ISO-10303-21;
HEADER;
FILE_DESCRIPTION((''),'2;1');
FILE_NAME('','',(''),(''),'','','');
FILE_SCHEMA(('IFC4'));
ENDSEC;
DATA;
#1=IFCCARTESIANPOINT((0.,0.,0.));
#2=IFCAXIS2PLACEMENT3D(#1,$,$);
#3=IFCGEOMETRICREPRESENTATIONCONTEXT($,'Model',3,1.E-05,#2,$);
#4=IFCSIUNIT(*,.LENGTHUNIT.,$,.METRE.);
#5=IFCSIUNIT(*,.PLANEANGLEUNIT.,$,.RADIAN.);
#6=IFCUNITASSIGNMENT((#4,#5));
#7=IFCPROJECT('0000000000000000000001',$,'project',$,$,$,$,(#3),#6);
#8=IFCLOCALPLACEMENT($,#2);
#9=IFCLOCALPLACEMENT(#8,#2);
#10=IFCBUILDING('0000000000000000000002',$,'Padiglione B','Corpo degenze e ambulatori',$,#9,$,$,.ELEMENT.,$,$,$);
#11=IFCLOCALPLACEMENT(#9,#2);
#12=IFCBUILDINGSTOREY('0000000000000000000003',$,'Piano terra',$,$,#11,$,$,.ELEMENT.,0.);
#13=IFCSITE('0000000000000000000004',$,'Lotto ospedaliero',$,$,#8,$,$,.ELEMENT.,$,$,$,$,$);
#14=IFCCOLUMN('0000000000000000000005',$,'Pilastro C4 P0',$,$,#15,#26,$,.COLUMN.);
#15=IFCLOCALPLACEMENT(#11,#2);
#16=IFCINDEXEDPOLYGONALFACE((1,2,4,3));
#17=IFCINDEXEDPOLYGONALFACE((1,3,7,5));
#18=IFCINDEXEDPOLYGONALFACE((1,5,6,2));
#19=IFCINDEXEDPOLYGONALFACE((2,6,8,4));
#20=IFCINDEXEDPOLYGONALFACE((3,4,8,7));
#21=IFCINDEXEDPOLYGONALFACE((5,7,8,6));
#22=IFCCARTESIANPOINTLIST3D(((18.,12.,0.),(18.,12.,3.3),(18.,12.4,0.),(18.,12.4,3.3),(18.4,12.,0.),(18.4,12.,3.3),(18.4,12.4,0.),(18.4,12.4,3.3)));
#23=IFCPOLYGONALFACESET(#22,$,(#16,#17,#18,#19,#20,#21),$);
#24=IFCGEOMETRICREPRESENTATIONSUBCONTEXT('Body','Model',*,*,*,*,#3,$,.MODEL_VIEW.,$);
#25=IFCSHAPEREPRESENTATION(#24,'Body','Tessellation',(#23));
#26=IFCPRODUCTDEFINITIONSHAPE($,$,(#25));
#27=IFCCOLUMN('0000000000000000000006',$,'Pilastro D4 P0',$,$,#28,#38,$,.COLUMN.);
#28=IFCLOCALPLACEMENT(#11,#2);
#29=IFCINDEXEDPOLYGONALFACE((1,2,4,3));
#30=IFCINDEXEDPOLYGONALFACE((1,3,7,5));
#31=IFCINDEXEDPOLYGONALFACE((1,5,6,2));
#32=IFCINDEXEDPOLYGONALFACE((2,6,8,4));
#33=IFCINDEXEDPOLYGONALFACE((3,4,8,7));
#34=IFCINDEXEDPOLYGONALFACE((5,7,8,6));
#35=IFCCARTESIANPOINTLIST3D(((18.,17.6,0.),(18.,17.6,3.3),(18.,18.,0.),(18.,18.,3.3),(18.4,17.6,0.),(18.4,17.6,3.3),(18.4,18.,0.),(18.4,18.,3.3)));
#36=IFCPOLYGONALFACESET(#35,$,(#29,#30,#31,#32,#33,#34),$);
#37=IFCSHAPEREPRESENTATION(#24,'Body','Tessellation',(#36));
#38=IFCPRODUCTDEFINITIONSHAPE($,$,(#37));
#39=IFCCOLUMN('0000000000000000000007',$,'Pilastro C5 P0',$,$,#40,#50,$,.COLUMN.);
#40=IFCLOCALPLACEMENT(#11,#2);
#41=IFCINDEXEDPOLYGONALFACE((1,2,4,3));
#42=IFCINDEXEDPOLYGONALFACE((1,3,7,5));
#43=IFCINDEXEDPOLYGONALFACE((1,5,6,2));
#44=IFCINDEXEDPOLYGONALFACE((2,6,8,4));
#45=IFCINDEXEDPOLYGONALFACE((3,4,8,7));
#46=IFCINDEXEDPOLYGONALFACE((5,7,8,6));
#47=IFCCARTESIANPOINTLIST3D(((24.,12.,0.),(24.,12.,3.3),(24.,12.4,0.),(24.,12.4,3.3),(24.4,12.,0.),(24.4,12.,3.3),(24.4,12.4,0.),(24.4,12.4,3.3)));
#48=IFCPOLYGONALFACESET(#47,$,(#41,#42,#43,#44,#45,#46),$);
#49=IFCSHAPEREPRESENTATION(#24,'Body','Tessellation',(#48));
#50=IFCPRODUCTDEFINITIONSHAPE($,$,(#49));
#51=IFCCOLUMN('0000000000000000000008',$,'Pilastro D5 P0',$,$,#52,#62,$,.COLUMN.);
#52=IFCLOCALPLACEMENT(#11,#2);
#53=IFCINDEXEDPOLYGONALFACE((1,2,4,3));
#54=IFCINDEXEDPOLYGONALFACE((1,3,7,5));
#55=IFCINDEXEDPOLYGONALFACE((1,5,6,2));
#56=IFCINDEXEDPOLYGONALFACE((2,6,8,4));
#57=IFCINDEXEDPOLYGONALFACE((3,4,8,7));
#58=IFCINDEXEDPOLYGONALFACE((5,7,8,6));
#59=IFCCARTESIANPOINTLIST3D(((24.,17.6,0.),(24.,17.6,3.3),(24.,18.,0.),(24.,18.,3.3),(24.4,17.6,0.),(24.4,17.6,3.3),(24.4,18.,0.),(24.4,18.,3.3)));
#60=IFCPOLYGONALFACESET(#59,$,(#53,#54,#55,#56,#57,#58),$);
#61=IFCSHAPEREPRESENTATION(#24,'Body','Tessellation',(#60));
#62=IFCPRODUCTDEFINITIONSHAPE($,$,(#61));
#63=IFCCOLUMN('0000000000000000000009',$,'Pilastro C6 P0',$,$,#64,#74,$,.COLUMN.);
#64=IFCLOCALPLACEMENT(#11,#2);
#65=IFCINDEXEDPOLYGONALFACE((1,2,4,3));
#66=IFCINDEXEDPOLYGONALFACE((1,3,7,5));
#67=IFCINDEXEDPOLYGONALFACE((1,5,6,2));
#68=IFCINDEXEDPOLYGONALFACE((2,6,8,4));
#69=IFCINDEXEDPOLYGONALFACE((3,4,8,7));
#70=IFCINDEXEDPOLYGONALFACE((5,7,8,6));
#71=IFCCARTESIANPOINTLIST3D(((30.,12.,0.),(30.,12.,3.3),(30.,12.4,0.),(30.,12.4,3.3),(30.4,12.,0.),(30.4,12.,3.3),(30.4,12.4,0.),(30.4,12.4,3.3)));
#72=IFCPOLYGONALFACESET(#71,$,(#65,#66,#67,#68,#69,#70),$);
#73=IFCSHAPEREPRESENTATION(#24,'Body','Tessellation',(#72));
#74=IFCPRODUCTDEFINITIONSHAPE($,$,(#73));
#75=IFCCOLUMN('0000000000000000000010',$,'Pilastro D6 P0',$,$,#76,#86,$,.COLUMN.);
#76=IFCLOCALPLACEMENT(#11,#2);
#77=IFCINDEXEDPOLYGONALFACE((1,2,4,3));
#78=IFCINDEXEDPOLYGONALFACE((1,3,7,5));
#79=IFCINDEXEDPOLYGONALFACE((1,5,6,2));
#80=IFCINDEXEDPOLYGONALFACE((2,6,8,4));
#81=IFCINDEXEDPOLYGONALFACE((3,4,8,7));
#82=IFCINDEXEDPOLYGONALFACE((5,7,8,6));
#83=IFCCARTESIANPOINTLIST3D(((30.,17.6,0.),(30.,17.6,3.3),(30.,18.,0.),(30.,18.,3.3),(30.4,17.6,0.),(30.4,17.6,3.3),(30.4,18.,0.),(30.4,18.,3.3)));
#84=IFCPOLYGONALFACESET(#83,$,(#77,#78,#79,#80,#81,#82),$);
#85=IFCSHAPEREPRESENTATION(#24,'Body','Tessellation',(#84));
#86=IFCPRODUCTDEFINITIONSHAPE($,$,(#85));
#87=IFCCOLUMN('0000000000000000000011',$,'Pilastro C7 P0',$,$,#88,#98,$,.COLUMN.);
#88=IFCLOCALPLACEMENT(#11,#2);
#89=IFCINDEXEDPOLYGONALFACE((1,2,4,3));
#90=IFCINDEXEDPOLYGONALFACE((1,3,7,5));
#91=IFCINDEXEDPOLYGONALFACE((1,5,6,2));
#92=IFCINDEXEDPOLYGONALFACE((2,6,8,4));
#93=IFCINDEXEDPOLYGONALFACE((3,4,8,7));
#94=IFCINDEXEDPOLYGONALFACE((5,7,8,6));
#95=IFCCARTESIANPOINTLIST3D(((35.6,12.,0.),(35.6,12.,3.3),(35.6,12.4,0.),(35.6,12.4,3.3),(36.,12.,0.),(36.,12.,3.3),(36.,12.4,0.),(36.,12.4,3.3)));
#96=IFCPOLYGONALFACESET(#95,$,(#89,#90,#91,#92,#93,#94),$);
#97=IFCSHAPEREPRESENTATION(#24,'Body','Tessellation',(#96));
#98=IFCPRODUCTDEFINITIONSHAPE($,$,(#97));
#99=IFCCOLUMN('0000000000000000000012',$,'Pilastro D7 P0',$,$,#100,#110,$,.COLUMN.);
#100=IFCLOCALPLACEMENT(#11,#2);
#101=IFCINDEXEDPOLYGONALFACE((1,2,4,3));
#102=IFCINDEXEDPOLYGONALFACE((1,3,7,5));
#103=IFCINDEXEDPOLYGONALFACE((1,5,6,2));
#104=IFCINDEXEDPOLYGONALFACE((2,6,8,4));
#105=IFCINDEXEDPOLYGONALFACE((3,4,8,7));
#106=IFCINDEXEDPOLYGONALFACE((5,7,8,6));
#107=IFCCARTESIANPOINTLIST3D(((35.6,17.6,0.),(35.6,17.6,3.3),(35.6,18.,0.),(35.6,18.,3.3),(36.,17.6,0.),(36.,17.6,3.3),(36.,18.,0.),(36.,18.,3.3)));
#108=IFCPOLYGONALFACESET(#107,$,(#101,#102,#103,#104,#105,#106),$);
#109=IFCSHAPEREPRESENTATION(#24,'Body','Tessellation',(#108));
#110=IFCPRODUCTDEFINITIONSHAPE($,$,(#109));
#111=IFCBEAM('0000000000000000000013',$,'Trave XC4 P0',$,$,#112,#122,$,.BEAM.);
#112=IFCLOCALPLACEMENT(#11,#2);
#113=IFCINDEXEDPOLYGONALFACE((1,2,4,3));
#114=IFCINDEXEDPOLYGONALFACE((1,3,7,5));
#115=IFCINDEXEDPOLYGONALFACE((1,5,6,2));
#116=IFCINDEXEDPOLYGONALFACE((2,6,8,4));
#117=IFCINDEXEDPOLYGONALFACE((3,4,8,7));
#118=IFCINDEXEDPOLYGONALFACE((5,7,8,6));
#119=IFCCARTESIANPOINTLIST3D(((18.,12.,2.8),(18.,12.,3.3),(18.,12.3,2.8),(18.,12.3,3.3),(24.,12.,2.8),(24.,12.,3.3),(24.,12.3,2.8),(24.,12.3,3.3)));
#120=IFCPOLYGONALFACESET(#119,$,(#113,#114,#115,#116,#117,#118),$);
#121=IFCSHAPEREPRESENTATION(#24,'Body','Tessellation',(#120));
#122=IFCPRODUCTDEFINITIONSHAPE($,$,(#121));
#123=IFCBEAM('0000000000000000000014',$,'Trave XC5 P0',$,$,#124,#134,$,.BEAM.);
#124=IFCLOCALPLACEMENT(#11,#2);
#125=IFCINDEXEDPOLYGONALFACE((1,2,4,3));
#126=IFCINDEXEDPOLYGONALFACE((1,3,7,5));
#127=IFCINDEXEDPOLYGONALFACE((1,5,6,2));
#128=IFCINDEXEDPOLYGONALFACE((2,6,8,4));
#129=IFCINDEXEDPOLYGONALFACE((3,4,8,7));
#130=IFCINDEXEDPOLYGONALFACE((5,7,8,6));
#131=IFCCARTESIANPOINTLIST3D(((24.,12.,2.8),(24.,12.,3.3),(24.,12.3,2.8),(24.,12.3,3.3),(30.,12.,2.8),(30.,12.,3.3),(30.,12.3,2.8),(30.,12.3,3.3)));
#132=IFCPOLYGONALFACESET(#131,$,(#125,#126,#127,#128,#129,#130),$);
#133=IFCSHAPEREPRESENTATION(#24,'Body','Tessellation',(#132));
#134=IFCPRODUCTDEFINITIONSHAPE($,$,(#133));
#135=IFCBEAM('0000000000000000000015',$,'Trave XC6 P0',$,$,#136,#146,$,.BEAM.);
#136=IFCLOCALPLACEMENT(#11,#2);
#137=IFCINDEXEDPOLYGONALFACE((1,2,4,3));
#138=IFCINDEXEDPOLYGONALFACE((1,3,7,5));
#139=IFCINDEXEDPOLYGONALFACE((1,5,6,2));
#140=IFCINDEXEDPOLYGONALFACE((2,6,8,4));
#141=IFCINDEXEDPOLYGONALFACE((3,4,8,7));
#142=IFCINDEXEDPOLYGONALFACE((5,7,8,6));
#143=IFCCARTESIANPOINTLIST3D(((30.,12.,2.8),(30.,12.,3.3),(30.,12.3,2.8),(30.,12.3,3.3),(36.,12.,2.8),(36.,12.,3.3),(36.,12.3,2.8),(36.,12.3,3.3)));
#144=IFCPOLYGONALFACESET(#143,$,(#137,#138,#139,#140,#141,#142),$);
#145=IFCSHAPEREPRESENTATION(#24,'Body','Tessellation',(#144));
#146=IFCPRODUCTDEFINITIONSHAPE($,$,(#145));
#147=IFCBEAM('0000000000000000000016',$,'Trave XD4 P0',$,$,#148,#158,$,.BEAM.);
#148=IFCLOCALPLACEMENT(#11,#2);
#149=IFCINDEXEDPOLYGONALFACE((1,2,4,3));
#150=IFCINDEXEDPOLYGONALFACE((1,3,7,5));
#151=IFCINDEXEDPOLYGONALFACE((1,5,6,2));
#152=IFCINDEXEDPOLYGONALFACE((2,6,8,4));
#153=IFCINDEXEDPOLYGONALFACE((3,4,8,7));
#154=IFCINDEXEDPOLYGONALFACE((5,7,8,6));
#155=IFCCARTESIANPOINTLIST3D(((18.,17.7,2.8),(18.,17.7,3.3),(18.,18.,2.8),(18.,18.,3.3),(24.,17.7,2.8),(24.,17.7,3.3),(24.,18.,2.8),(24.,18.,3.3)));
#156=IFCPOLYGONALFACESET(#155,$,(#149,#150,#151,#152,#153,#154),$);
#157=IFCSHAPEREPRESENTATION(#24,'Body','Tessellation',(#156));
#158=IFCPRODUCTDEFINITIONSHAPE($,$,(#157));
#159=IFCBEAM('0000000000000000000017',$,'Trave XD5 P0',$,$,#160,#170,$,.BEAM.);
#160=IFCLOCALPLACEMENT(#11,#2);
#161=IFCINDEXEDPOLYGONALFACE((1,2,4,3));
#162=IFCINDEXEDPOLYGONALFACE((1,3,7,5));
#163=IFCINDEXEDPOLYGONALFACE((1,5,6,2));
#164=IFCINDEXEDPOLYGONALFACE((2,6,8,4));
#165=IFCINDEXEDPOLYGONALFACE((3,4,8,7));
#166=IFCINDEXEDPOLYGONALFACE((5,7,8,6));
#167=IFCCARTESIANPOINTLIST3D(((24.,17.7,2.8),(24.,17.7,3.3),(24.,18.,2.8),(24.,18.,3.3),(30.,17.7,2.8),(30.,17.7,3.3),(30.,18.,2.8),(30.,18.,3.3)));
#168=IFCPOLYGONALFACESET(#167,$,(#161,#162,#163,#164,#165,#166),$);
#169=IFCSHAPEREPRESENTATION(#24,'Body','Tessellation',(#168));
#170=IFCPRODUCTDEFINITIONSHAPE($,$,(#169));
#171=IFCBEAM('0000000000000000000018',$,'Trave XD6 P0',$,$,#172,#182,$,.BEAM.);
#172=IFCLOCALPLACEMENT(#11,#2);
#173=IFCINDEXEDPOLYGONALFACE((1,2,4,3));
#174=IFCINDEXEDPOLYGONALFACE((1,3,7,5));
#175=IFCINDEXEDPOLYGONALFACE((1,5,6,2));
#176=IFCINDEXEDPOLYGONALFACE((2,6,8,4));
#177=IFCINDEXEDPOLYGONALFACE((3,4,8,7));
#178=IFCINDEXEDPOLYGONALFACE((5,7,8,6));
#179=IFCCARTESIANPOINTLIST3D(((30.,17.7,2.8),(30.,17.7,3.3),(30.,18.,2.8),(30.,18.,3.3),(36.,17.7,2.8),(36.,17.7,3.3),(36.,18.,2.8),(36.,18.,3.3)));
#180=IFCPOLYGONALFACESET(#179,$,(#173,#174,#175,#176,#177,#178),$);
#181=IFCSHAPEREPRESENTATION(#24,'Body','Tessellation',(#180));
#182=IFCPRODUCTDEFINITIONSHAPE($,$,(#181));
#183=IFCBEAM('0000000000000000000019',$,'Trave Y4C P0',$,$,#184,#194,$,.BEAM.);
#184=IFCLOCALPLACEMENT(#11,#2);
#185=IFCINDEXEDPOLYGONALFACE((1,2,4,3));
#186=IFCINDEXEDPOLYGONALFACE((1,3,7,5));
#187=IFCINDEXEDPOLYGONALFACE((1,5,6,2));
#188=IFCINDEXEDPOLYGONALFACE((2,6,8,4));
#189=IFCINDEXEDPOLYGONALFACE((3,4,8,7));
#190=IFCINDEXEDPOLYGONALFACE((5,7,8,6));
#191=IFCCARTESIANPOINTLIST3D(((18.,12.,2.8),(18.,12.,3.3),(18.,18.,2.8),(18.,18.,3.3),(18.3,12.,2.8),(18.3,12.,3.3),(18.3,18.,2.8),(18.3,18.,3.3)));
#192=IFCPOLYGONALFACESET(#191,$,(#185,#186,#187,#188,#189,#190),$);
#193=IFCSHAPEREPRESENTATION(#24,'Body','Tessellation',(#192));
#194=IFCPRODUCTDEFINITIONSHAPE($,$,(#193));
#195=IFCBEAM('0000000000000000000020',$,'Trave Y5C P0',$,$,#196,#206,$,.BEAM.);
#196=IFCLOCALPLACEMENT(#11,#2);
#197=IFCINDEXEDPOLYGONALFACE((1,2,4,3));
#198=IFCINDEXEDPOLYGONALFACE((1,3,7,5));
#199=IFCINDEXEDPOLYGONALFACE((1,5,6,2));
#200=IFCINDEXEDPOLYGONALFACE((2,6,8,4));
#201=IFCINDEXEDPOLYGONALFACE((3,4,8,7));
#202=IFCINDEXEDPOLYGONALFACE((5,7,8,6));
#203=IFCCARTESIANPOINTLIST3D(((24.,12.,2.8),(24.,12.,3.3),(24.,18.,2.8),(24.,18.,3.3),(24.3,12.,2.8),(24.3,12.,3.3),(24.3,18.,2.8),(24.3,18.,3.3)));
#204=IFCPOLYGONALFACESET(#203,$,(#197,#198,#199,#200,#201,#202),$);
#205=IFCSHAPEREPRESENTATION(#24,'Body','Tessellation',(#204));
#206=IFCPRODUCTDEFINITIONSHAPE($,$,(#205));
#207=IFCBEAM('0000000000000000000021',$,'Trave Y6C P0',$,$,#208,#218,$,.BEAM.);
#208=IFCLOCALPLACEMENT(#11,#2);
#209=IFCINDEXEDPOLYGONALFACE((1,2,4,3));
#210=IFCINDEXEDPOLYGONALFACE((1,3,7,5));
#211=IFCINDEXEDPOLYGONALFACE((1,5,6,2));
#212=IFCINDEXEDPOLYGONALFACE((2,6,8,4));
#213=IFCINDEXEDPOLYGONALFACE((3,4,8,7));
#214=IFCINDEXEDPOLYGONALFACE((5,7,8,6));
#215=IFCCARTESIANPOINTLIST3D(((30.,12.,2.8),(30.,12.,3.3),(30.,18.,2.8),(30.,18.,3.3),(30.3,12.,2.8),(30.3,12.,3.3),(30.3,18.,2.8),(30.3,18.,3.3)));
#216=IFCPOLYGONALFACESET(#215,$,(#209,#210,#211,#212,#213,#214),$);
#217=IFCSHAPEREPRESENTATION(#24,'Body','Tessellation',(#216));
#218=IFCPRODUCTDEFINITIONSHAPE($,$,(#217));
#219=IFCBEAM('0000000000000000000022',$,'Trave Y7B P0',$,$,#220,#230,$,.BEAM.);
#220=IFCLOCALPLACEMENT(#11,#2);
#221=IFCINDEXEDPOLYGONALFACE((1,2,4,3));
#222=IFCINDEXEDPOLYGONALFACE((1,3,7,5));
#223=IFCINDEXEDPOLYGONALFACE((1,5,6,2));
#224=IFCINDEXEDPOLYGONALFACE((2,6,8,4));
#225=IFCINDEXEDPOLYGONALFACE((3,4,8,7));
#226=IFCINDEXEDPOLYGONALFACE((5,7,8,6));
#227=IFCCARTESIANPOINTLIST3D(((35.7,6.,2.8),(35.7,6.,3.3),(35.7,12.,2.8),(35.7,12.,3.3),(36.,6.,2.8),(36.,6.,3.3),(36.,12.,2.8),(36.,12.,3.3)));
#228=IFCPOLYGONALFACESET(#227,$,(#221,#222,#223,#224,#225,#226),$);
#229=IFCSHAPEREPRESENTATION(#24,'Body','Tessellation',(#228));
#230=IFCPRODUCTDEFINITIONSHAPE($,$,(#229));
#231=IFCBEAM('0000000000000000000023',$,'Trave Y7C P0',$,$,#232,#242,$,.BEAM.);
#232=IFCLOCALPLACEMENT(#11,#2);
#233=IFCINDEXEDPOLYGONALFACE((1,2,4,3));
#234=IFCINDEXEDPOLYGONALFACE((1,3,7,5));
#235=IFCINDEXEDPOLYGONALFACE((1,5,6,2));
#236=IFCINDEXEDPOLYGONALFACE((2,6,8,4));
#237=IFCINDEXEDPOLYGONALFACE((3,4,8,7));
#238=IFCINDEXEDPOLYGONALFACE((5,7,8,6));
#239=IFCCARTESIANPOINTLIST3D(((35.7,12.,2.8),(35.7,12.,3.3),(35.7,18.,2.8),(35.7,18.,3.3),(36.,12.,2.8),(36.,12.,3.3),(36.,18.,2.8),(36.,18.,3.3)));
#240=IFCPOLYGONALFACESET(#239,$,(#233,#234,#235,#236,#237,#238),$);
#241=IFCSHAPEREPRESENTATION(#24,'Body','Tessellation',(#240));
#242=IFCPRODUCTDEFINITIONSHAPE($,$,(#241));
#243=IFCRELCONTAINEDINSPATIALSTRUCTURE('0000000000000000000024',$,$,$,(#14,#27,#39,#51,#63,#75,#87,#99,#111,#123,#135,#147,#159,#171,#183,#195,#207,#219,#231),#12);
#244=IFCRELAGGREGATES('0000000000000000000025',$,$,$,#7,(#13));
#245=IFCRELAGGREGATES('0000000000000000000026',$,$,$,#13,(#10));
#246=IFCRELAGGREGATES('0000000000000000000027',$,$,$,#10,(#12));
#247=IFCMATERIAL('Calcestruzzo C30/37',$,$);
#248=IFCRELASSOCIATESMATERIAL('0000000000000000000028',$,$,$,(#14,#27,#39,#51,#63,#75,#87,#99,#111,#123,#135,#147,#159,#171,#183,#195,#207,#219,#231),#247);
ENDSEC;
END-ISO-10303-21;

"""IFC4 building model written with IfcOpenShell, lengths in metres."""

from ifc_helpers import new_model, si_unit, frame, frame_2d, origin, place, context, subcontext, project, spatial, rectangle, extrude, material, element, save


model = new_model("IFC4")

# Units and contexts
model_context = context("Model", 3, precision=1e-05, world=origin())
body_context = subcontext(model_context, "Body", "Model", "MODEL_VIEW")
ifc_project = project(units=[si_unit("LENGTHUNIT", "METRE"), si_unit("PLANEANGLEUNIT", "RADIAN")], contexts=[model_context])

# Site, building, storey
site_placement = place(None, origin())
site = spatial("IfcSite", under=ifc_project, at=site_placement, Name="Lotto ospedaliero", CompositionType="ELEMENT")
building_placement = place(site_placement, origin())
building = spatial("IfcBuilding", under=site, at=building_placement, Name="Padiglione B", Description="Corpo degenze e ambulatori", CompositionType="ELEMENT")
storey_placement = place(building_placement, origin())
storey = spatial("IfcBuildingStorey", under=building, at=storey_placement, Name="Piano terra", CompositionType="ELEMENT", Elevation=0.0)

# Columns
ifc_material_1 = material(Name="Calcestruzzo C30/37")
for number, where, name in (
    (1, (18.0, 12.0, 0.0), "Pilastro C4 P0"),
    (2, (18.0, 17.6, 0.0), "Pilastro D4 P0"),
    (3, (24.0, 12.0, 0.0), "Pilastro C5 P0"),
    (4, (24.0, 17.6, 0.0), "Pilastro D5 P0"),
    (5, (30.0, 12.0, 0.0), "Pilastro C6 P0"),
    (6, (30.0, 17.6, 0.0), "Pilastro D6 P0"),
    (7, (35.6, 12.0, 0.0), "Pilastro C7 P0"),
    (8, (35.6, 17.6, 0.0), "Pilastro D7 P0"),
):
    element("IfcColumn", number, at=place(storey_placement, frame(where)), inside=storey, material=ifc_material_1, Name=name, PredefinedType="COLUMN", context=body_context, shape_type="SweptSolid", body=[
        extrude(rectangle(XDim=0.4, YDim=0.4, at=frame_2d((0.2, 0.2))), origin(), (0.0, 0.0, 1.0), 3.3),
    ])

# Beams
for number, where, name in (
    (9, (18.0, 12.0, 2.8), "Trave XC4 P0"),
    (10, (24.0, 12.0, 2.8), "Trave XC5 P0"),
    (11, (30.0, 12.0, 2.8), "Trave XC6 P0"),
    (12, (18.0, 17.7, 2.8), "Trave XD4 P0"),
    (13, (24.0, 17.7, 2.8), "Trave XD5 P0"),
    (14, (30.0, 17.7, 2.8), "Trave XD6 P0"),
):
    element("IfcBeam", number, at=place(storey_placement, frame(where)), inside=storey, material=ifc_material_1, Name=name, PredefinedType="BEAM", context=body_context, shape_type="SweptSolid", body=[
        extrude(rectangle(XDim=6.0, YDim=0.3, at=frame_2d((3.0, 0.15))), origin(), (0.0, 0.0, 1.0), 0.5),
    ])
for number, where, name in (
    (15, (18.0, 12.0, 2.8), "Trave Y4C P0"),
    (16, (24.0, 12.0, 2.8), "Trave Y5C P0"),
    (17, (30.0, 12.0, 2.8), "Trave Y6C P0"),
    (18, (35.7, 6.0, 2.8), "Trave Y7B P0"),
    (19, (35.7, 12.0, 2.8), "Trave Y7C P0"),
):
    element("IfcBeam", number, at=place(storey_placement, frame(where)), inside=storey, material=ifc_material_1, Name=name, PredefinedType="BEAM", context=body_context, shape_type="SweptSolid", body=[
        extrude(rectangle(XDim=0.3, YDim=6.0, at=frame_2d((0.15, 3.0))), origin(), (0.0, 0.0, 1.0), 0.5),
    ])

save(model, "model.ifc")
